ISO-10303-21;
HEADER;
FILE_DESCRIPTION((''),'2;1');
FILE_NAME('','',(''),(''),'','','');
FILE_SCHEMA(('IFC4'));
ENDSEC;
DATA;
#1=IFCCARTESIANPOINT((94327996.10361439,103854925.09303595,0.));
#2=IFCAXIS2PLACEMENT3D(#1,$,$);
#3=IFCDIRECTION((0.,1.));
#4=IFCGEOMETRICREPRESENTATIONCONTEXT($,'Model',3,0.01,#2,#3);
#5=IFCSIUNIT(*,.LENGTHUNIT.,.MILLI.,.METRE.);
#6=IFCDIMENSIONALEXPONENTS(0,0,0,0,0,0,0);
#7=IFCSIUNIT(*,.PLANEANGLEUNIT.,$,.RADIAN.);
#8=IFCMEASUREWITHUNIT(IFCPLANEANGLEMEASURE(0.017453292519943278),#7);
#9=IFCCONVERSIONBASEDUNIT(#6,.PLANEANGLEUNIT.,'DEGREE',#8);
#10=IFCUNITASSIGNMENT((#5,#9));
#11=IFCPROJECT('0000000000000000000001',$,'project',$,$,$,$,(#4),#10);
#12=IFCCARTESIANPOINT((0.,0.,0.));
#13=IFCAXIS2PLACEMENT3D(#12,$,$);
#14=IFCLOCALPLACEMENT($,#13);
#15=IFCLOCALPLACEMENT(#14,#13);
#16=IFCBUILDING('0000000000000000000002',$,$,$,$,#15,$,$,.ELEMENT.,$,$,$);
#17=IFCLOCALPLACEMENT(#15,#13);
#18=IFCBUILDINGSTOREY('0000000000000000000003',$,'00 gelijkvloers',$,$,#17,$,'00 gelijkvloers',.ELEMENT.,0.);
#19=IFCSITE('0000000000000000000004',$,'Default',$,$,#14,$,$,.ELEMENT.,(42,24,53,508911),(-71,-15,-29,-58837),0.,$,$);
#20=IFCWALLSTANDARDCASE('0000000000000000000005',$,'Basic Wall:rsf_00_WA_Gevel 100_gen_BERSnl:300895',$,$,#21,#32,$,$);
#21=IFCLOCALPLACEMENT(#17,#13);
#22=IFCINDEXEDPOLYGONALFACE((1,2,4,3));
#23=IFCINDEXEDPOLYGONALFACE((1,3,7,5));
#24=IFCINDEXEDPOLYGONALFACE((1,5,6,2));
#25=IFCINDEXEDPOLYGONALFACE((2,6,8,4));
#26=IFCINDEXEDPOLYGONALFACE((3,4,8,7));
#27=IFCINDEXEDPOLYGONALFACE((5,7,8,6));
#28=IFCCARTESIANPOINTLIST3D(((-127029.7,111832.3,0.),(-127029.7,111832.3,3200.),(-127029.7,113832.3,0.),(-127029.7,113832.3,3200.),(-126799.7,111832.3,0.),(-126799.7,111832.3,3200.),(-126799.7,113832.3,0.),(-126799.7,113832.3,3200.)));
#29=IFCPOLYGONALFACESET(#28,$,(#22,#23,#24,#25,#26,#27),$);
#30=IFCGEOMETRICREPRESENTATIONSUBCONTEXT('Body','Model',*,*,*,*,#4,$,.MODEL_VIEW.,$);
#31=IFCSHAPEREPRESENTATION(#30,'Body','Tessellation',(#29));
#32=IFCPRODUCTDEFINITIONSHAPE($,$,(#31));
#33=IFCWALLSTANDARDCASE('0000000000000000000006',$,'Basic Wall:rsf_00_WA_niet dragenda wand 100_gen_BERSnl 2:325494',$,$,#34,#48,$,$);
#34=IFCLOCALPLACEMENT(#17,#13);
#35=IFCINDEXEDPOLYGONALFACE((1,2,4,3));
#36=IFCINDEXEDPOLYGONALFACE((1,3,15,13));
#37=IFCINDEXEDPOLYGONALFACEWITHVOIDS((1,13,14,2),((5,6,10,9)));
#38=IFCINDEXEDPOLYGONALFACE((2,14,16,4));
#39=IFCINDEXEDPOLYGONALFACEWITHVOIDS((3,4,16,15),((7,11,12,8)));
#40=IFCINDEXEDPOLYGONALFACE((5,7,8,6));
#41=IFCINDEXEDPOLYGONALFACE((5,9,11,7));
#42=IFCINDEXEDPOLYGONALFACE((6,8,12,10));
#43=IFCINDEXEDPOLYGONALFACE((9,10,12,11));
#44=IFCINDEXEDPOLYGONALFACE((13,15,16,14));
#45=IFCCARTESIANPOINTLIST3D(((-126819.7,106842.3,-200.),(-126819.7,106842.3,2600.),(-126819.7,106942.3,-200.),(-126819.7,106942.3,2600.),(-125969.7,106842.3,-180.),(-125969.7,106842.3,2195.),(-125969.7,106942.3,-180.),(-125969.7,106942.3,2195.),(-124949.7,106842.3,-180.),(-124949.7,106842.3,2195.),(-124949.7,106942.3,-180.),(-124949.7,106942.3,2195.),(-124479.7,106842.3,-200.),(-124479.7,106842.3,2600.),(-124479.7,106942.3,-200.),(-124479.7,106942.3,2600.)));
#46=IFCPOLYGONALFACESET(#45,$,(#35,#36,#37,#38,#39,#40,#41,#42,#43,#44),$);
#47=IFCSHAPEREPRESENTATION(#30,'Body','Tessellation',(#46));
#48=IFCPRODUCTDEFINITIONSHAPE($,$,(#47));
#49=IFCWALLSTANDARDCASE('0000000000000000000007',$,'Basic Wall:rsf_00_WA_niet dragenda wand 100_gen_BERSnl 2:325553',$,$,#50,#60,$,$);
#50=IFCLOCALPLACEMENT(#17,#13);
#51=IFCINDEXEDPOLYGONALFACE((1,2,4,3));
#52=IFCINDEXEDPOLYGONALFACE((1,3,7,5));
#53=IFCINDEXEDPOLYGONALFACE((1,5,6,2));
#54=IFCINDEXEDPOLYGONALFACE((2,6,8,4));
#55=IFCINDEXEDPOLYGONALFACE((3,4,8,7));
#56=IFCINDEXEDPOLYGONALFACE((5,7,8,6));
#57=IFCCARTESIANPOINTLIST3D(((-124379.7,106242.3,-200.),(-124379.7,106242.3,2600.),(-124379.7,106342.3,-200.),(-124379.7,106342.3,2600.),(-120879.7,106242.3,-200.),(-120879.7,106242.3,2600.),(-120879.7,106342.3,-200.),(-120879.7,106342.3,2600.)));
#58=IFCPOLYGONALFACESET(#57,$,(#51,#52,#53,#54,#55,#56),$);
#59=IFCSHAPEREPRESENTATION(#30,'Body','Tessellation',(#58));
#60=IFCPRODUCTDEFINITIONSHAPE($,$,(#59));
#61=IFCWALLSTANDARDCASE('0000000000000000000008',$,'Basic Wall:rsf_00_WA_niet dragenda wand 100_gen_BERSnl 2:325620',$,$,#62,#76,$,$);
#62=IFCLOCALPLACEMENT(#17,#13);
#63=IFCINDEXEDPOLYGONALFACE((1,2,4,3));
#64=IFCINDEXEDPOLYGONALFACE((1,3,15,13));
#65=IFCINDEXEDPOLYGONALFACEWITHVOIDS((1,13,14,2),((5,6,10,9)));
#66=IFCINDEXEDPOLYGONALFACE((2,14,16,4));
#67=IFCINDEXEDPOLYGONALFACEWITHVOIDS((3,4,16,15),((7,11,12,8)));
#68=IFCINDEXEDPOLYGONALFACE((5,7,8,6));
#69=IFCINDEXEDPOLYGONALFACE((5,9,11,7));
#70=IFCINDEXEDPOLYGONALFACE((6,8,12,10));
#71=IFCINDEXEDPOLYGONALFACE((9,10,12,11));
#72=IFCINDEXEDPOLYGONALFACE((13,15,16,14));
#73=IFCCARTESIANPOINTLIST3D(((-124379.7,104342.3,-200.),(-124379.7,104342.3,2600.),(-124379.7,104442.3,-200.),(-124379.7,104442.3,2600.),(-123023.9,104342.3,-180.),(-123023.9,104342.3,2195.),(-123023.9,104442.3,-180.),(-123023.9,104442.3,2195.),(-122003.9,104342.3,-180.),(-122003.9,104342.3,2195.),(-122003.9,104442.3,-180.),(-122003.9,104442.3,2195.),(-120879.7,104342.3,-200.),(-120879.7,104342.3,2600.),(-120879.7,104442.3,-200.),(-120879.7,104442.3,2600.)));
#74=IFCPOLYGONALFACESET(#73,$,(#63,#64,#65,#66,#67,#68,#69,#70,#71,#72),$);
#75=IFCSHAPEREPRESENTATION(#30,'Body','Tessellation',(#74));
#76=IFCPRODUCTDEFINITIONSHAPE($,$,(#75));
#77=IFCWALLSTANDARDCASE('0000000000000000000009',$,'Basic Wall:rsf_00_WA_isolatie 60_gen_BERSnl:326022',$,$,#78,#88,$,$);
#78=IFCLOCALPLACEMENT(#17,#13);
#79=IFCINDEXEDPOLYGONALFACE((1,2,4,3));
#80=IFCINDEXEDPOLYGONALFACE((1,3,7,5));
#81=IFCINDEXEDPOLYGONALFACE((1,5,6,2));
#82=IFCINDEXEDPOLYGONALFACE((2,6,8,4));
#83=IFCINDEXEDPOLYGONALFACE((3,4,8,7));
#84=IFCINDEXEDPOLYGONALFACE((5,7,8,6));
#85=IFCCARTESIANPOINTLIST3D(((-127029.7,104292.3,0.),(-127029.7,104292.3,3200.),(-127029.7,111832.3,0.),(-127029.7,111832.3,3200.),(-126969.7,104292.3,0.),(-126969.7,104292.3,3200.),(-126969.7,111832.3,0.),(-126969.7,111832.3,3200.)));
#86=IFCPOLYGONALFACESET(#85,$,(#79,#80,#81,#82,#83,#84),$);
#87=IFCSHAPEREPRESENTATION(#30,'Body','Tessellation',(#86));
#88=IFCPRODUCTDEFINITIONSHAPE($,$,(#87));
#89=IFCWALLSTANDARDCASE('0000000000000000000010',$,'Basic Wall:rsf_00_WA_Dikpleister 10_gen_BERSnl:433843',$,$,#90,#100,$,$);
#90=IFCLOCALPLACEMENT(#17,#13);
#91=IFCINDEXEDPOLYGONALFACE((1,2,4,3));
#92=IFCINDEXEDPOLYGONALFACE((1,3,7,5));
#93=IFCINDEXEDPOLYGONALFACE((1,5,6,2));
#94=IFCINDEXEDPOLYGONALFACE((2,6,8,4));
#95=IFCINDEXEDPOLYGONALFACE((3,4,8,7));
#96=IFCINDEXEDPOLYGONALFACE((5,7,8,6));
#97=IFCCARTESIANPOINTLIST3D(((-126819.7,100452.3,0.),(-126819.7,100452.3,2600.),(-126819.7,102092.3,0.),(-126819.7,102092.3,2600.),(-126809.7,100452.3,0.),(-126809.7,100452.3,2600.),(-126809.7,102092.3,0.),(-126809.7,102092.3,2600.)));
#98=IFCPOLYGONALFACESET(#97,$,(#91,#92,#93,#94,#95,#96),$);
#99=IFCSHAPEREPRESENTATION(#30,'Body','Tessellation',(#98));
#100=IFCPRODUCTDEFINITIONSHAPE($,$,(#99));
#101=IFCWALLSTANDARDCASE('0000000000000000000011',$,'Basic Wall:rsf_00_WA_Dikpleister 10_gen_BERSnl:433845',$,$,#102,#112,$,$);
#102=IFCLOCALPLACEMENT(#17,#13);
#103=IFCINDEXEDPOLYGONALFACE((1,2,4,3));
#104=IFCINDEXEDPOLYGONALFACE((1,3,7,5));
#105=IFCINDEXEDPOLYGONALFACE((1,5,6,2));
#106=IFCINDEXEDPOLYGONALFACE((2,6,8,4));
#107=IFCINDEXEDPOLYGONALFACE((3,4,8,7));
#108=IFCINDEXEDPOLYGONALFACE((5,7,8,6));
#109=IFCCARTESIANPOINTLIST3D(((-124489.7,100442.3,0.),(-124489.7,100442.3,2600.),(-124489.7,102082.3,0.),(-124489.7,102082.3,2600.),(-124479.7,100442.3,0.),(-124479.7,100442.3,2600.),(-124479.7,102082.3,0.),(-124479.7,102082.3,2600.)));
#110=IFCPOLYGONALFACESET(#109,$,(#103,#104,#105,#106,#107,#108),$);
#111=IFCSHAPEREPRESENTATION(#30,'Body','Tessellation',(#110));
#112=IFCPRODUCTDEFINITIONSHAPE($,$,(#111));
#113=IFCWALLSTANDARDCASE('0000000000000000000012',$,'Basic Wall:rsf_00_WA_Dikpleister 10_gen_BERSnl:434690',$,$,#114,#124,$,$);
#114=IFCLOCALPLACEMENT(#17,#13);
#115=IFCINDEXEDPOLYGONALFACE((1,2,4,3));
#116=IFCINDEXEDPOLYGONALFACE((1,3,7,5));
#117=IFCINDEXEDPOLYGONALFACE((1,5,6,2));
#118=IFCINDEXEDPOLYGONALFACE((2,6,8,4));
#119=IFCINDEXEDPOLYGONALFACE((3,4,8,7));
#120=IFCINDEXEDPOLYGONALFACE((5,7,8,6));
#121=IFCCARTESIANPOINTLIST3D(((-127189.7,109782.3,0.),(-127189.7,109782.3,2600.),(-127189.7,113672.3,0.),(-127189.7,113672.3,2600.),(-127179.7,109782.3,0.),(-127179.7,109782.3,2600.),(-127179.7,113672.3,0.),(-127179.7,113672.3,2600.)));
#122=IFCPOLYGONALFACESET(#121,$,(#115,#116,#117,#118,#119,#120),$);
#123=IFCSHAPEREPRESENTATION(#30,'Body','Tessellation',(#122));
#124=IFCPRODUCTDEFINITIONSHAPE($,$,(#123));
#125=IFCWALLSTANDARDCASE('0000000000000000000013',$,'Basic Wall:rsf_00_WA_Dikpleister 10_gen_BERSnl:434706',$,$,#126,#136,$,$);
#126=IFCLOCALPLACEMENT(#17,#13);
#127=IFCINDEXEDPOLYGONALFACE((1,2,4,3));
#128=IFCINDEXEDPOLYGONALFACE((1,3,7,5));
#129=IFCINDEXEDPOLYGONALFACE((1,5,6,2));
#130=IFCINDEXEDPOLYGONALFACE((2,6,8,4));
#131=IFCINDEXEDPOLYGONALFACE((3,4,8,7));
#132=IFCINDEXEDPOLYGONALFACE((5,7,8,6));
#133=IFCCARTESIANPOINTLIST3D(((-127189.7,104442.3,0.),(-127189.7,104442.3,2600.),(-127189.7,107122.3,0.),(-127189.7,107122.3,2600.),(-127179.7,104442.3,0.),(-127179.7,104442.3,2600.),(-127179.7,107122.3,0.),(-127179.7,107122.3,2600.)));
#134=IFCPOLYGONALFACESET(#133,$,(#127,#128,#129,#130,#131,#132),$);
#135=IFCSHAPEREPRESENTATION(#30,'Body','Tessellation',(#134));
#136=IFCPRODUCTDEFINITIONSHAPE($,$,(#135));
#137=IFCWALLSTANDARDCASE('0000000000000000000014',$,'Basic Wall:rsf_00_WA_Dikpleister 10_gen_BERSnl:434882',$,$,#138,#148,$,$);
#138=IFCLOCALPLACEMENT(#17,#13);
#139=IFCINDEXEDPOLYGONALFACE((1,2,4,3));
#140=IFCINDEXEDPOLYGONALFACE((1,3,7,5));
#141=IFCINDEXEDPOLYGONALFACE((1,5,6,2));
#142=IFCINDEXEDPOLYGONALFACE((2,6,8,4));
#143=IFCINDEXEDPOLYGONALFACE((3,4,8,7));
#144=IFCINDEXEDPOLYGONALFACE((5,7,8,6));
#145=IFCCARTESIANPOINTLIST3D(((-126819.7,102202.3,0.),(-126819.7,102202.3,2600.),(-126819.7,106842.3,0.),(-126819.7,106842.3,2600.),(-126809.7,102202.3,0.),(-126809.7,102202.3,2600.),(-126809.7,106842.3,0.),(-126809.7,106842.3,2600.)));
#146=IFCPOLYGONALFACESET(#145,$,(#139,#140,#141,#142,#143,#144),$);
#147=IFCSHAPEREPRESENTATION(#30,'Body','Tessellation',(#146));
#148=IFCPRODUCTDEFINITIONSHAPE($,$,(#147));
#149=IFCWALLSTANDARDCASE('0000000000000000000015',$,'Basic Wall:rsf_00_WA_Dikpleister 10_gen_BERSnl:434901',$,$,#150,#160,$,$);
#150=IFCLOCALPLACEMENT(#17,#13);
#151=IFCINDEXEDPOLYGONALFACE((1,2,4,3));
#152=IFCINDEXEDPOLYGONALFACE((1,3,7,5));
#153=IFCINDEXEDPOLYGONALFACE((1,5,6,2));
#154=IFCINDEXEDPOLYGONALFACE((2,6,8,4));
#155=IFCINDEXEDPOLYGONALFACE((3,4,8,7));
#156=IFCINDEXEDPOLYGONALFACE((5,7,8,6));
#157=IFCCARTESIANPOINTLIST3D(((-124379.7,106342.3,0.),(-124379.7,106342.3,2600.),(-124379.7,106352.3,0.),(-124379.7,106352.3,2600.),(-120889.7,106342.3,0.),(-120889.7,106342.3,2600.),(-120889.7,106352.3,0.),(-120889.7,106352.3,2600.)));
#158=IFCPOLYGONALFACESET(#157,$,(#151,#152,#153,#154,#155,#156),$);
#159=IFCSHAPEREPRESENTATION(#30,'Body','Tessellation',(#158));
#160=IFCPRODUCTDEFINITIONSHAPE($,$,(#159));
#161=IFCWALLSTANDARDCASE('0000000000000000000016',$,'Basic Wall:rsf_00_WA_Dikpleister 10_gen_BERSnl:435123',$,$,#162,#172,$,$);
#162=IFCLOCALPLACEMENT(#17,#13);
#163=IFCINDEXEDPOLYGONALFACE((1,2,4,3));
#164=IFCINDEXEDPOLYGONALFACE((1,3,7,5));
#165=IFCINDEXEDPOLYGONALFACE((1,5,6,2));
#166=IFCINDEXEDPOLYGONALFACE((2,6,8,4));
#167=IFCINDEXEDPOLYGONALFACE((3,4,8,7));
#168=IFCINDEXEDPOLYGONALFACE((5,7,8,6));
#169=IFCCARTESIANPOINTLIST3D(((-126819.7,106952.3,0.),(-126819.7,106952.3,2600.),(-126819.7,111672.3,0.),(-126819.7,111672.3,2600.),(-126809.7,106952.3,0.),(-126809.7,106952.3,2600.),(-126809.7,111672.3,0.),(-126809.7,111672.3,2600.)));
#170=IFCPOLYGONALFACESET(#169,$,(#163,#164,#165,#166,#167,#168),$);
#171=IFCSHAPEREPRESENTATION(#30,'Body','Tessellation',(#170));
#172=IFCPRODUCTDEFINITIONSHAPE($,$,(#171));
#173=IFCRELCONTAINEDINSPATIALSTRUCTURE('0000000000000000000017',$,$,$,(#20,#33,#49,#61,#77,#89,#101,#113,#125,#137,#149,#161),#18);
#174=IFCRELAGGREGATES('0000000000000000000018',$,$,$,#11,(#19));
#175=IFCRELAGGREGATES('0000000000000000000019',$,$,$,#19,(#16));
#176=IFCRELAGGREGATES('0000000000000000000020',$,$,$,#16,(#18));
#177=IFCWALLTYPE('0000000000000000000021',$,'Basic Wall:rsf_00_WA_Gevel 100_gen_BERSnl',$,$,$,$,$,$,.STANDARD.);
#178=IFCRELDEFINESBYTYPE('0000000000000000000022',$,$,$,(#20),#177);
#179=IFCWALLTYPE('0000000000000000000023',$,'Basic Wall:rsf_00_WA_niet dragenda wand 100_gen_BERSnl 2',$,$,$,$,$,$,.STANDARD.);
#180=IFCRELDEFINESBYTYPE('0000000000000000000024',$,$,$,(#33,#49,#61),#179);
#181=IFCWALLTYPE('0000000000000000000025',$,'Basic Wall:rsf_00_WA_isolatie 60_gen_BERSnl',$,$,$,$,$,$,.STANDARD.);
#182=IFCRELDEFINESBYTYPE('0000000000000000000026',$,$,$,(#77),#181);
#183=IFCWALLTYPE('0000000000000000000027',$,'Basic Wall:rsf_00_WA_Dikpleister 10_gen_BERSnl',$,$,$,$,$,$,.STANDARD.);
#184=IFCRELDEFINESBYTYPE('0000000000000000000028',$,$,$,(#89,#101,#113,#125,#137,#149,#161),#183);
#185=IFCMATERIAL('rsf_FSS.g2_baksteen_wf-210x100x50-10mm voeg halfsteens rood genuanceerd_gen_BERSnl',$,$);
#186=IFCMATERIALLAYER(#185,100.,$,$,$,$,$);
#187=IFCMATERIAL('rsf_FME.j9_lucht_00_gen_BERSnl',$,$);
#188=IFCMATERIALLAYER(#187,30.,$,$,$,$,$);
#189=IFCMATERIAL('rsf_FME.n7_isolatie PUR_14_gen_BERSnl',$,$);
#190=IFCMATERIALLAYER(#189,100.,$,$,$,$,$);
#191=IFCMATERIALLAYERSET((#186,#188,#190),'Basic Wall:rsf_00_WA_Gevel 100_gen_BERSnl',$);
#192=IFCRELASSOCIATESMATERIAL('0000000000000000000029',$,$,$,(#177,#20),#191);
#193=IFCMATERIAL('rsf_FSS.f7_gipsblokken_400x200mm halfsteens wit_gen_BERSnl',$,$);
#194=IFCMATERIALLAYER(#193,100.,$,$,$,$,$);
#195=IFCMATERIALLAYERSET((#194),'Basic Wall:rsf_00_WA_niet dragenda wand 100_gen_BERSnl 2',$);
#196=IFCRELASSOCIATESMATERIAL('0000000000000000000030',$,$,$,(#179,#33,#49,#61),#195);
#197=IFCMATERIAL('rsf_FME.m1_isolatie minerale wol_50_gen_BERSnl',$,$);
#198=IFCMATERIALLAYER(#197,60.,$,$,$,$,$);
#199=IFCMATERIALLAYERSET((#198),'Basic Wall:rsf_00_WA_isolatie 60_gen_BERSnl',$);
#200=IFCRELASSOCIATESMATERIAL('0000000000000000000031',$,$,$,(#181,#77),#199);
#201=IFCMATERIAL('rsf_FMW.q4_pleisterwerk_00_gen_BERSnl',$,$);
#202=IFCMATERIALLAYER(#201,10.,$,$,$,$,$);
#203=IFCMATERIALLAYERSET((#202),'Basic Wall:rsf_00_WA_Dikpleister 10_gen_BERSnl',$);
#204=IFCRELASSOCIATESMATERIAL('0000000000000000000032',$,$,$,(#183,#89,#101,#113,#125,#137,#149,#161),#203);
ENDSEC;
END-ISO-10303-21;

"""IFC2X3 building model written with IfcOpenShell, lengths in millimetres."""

from ifc_helpers import new_model, entity, si_unit, converted_unit, direction, frame, frame_2d, origin, place, context, subcontext, project, spatial, rectangle, extrude, material, layer, layer_set, layer_usage, type_object, element, save


model = new_model("IFC2X3")

# Units and contexts
model_context = context("Model", 3, precision=0.01, world=frame((94327996.10361439, 103854925.09303595, 0.0)), true_north=direction((0.0, 1.0)))
body_context = subcontext(model_context, "Body", "Model", "MODEL_VIEW")
ifc_project = project(units=[si_unit("LENGTHUNIT", "METRE", prefix="MILLI"), converted_unit("PLANEANGLEUNIT", "DEGREE", entity("IfcPlaneAngleMeasure", 0.017453292519943278), si_unit("PLANEANGLEUNIT", "RADIAN"), dimensions=[0, 0, 0, 0, 0, 0, 0])], contexts=[model_context])

# Site, building, storey
site_placement = place(None, origin())
site = spatial("IfcSite", under=ifc_project, at=site_placement, Name="Default", CompositionType="ELEMENT", RefLatitude=(42, 24, 53, 508911), RefLongitude=(-71, -15, -29, -58837), RefElevation=0.0)
building_placement = place(site_placement, origin())
building = spatial("IfcBuilding", under=site, at=building_placement, CompositionType="ELEMENT")
storey_placement = place(building_placement, origin())
storey = spatial("IfcBuildingStorey", under=building, at=storey_placement, Name="00 gelijkvloers", LongName="00 gelijkvloers", CompositionType="ELEMENT", Elevation=0.0)

# Wall
ifc_material_1 = material(Name="rsf_FSS.g2_baksteen_wf-210x100x50-10mm voeg halfsteens rood genuanceerd_gen_BERSnl")
ifc_layer_1 = layer(ifc_material_1, 100.0)
ifc_material_2 = material(Name="rsf_FME.j9_lucht_00_gen_BERSnl")
ifc_layer_2 = layer(ifc_material_2, 30.0)
ifc_material_3 = material(Name="rsf_FME.n7_isolatie PUR_14_gen_BERSnl")
ifc_layer_3 = layer(ifc_material_3, 100.0)
ifc_layer_set_1 = layer_set([ifc_layer_1, ifc_layer_2, ifc_layer_3], Name="Basic Wall:rsf_00_WA_Gevel 100_gen_BERSnl")
ifc_layer_usage_1 = layer_usage(ifc_layer_set_1, "AXIS2", "NEGATIVE", 115.0)
wall_type_1 = type_object("IfcWallType", Name="Basic Wall:rsf_00_WA_Gevel 100_gen_BERSnl", PredefinedType="STANDARD", material=ifc_layer_set_1)
wall_1_placement = place(storey_placement, frame((-126914.7, 113832.3, 0.0), z_axis=(0.0, 0.0, 1.0), x_axis=(0.0, -1.0, 0.0)))
element("IfcWallStandardCase", 1, at=wall_1_placement, inside=storey, type_object=wall_type_1, material=ifc_layer_usage_1, Name="Basic Wall:rsf_00_WA_Gevel 100_gen_BERSnl:300895", context=body_context, shape_type="SweptSolid", body=[
    extrude(rectangle(XDim=2000.0, YDim=230.0, at=frame_2d((1000.0, 0.0), x_axis=(-1.0, 0.0))), origin(), (0.0, 0.0, 1.0), 3200.0),
])

# Wall, opening
ifc_material_4 = material(Name="rsf_FSS.f7_gipsblokken_400x200mm halfsteens wit_gen_BERSnl")
ifc_layer_4 = layer(ifc_material_4, 100.0)
ifc_layer_set_2 = layer_set([ifc_layer_4], Name="Basic Wall:rsf_00_WA_niet dragenda wand 100_gen_BERSnl 2")
ifc_layer_usage_2 = layer_usage(ifc_layer_set_2, "AXIS2", "NEGATIVE", 50.0)
wall_type_2 = type_object("IfcWallType", Name="Basic Wall:rsf_00_WA_niet dragenda wand 100_gen_BERSnl 2", PredefinedType="STANDARD", material=ifc_layer_set_2)
wall_2_placement = place(storey_placement, frame((-124479.7, 106892.3, -200.0), z_axis=(0.0, 0.0, 1.0), x_axis=(-1.0, 0.0, 0.0)))
wall_2 = element("IfcWallStandardCase", 2, at=wall_2_placement, inside=storey, type_object=wall_type_2, material=ifc_layer_usage_2, Name="Basic Wall:rsf_00_WA_niet dragenda wand 100_gen_BERSnl 2:325494", context=body_context, shape_type="SweptSolid", body=[
    extrude(rectangle(XDim=2340.0, YDim=100.0, at=frame_2d((1170.0, 0.0), x_axis=(-1.0, 0.0))), origin(), (0.0, 0.0, 1.0), 2800.0),
])
opening_1_placement = place(wall_2_placement, frame((1490.0, 50.0, 20.0)))
element("IfcOpeningElement", 3, at=opening_1_placement, cuts=wall_2, ObjectType="Opening", context=body_context, shape_type="SweptSolid", body=[
    extrude(rectangle(XDim=2375.0, YDim=1020.0, at=frame_2d((1187.5, 510.0), x_axis=(-1.0, 0.0))), frame((0.0, 0.0, 0.0), z_axis=(0.0, -1.0, 0.0), x_axis=(0.0, 0.0, 1.0)), (0.0, 0.0, 1.0), 100.0),
])

# Wall
ifc_layer_usage_3 = layer_usage(ifc_layer_set_2, "AXIS2", "POSITIVE", -50.0)
wall_3_placement = place(storey_placement, frame((-124379.7, 106292.3, -200.0)))
element("IfcWallStandardCase", 4, at=wall_3_placement, inside=storey, type_object=wall_type_2, material=ifc_layer_usage_3, Name="Basic Wall:rsf_00_WA_niet dragenda wand 100_gen_BERSnl 2:325553", context=body_context, shape_type="SweptSolid", body=[
    extrude(rectangle(XDim=3500.0, YDim=100.0, at=frame_2d((1750.0, 0.0), x_axis=(-1.0, 0.0))), origin(), (0.0, 0.0, 1.0), 2800.0),
])

# Wall, opening
ifc_layer_usage_4 = layer_usage(ifc_layer_set_2, "AXIS2", "POSITIVE", -50.0)
wall_4_placement = place(storey_placement, frame((-124379.7, 104392.3, -200.0)))
wall_4 = element("IfcWallStandardCase", 5, at=wall_4_placement, inside=storey, type_object=wall_type_2, material=ifc_layer_usage_4, Name="Basic Wall:rsf_00_WA_niet dragenda wand 100_gen_BERSnl 2:325620", context=body_context, shape_type="SweptSolid", body=[
    extrude(rectangle(XDim=3500.0, YDim=100.0, at=frame_2d((1750.0, 0.0), x_axis=(-1.0, 0.0))), origin(), (0.0, 0.0, 1.0), 2800.0),
])
opening_2_placement = place(wall_4_placement, frame((2375.8, 50.0, 20.0)))
element("IfcOpeningElement", 6, at=opening_2_placement, cuts=wall_4, ObjectType="Opening", context=body_context, shape_type="SweptSolid", body=[
    extrude(rectangle(XDim=2375.0, YDim=1020.0, at=frame_2d((1187.5, 510.0), x_axis=(-1.0, 0.0))), frame((0.0, 0.0, 0.0), z_axis=(0.0, -1.0, 0.0), x_axis=(0.0, 0.0, 1.0)), (0.0, 0.0, 1.0), 100.0),
])

# Walls
ifc_material_5 = material(Name="rsf_FME.m1_isolatie minerale wol_50_gen_BERSnl")
ifc_layer_5 = layer(ifc_material_5, 60.0)
ifc_layer_set_3 = layer_set([ifc_layer_5], Name="Basic Wall:rsf_00_WA_isolatie 60_gen_BERSnl")
ifc_layer_usage_5 = layer_usage(ifc_layer_set_3, "AXIS2", "NEGATIVE", 30.0)
wall_type_3 = type_object("IfcWallType", Name="Basic Wall:rsf_00_WA_isolatie 60_gen_BERSnl", PredefinedType="STANDARD", material=ifc_layer_set_3)
wall_5_placement = place(storey_placement, frame((-126999.7, 111832.3, 0.0), z_axis=(0.0, 0.0, 1.0), x_axis=(0.0, -1.0, 0.0)))
element("IfcWallStandardCase", 7, at=wall_5_placement, inside=storey, type_object=wall_type_3, material=ifc_layer_usage_5, Name="Basic Wall:rsf_00_WA_isolatie 60_gen_BERSnl:326022", context=body_context, shape_type="SweptSolid", body=[
    extrude(rectangle(XDim=7540.0, YDim=60.0, at=frame_2d((3770.0, 0.0), x_axis=(-1.0, 0.0))), origin(), (0.0, 0.0, 1.0), 3200.0),
])
ifc_material_6 = material(Name="rsf_FMW.q4_pleisterwerk_00_gen_BERSnl")
ifc_layer_6 = layer(ifc_material_6, 10.0)
ifc_layer_set_4 = layer_set([ifc_layer_6], Name="Basic Wall:rsf_00_WA_Dikpleister 10_gen_BERSnl")
ifc_layer_usage_6 = layer_usage(ifc_layer_set_4, "AXIS2", "POSITIVE", -5.0)
wall_type_4 = type_object("IfcWallType", Name="Basic Wall:rsf_00_WA_Dikpleister 10_gen_BERSnl", PredefinedType="STANDARD", material=ifc_layer_set_4)
wall_6_placement = place(storey_placement, frame((-126814.7, 102092.3, 0.0), z_axis=(0.0, 0.0, 1.0), x_axis=(0.0, -1.0, 0.0)))
element("IfcWallStandardCase", 8, at=wall_6_placement, inside=storey, type_object=wall_type_4, material=ifc_layer_usage_6, Name="Basic Wall:rsf_00_WA_Dikpleister 10_gen_BERSnl:433843", context=body_context, shape_type="SweptSolid", body=[
    extrude(rectangle(XDim=1640.0, YDim=10.0, at=frame_2d((820.0, 0.0), x_axis=(-1.0, 0.0))), origin(), (0.0, 0.0, 1.0), 2600.0),
])

# Walls
ifc_layer_usage_7 = layer_usage(ifc_layer_set_4, "AXIS2", "POSITIVE", -5.0)
wall_7_placement = place(storey_placement, frame((-124484.7, 100442.3, 0.0), z_axis=(0.0, 0.0, 1.0), x_axis=(0.0, 1.0, 0.0)))
element("IfcWallStandardCase", 9, at=wall_7_placement, inside=storey, type_object=wall_type_4, material=ifc_layer_usage_7, Name="Basic Wall:rsf_00_WA_Dikpleister 10_gen_BERSnl:433845", context=body_context, shape_type="SweptSolid", body=[
    extrude(rectangle(XDim=1640.0, YDim=10.0, at=frame_2d((820.0, 0.0), x_axis=(-1.0, 0.0))), origin(), (0.0, 0.0, 1.0), 2600.0),
])
ifc_layer_usage_8 = layer_usage(ifc_layer_set_4, "AXIS2", "POSITIVE", -5.0)
wall_8_placement = place(storey_placement, frame((-127184.7, 109782.3, 0.0), z_axis=(0.0, 0.0, 1.0), x_axis=(0.0, 1.0, 0.0)))
element("IfcWallStandardCase", 10, at=wall_8_placement, inside=storey, type_object=wall_type_4, material=ifc_layer_usage_8, Name="Basic Wall:rsf_00_WA_Dikpleister 10_gen_BERSnl:434690", context=body_context, shape_type="SweptSolid", body=[
    extrude(rectangle(XDim=3890.0, YDim=10.0, at=frame_2d((1945.0, 0.0), x_axis=(-1.0, 0.0))), origin(), (0.0, 0.0, 1.0), 2600.0),
])

# Wall
ifc_layer_usage_9 = layer_usage(ifc_layer_set_4, "AXIS2", "POSITIVE", -5.0)
wall_9_placement = place(storey_placement, frame((-127184.7, 104442.3, 0.0), z_axis=(0.0, 0.0, 1.0), x_axis=(0.0, 1.0, 0.0)))
element("IfcWallStandardCase", 11, at=wall_9_placement, inside=storey, type_object=wall_type_4, material=ifc_layer_usage_9, Name="Basic Wall:rsf_00_WA_Dikpleister 10_gen_BERSnl:434706", context=body_context, shape_type="SweptSolid", body=[
    extrude(rectangle(XDim=2680.0, YDim=10.0, at=frame_2d((1340.0, 0.0), x_axis=(-1.0, 0.0))), origin(), (0.0, 0.0, 1.0), 2600.0),
])

# Wall
ifc_layer_usage_10 = layer_usage(ifc_layer_set_4, "AXIS2", "POSITIVE", -5.0)
wall_10_placement = place(storey_placement, frame((-126814.7, 106842.3, 0.0), z_axis=(0.0, 0.0, 1.0), x_axis=(0.0, -1.0, 0.0)))
element("IfcWallStandardCase", 12, at=wall_10_placement, inside=storey, type_object=wall_type_4, material=ifc_layer_usage_10, Name="Basic Wall:rsf_00_WA_Dikpleister 10_gen_BERSnl:434882", context=body_context, shape_type="SweptSolid", body=[
    extrude(rectangle(XDim=4640.0, YDim=10.0, at=frame_2d((2320.0, 0.0), x_axis=(-1.0, 0.0))), origin(), (0.0, 0.0, 1.0), 2600.0),
])

# Wall
ifc_layer_usage_11 = layer_usage(ifc_layer_set_4, "AXIS2", "POSITIVE", -5.0)
wall_11_placement = place(storey_placement, frame((-124379.7, 106347.3, 0.0)))
element("IfcWallStandardCase", 13, at=wall_11_placement, inside=storey, type_object=wall_type_4, material=ifc_layer_usage_11, Name="Basic Wall:rsf_00_WA_Dikpleister 10_gen_BERSnl:434901", context=body_context, shape_type="SweptSolid", body=[
    extrude(rectangle(XDim=3490.0, YDim=10.0, at=frame_2d((1745.0, 0.0), x_axis=(-1.0, 0.0))), origin(), (0.0, 0.0, 1.0), 2600.0),
])

# Wall
ifc_layer_usage_12 = layer_usage(ifc_layer_set_4, "AXIS2", "POSITIVE", -5.0)
wall_12_placement = place(storey_placement, frame((-126814.7, 106952.3, 0.0), z_axis=(0.0, 0.0, 1.0), x_axis=(0.0, 1.0, 0.0)))
element("IfcWallStandardCase", 14, at=wall_12_placement, inside=storey, type_object=wall_type_4, material=ifc_layer_usage_12, Name="Basic Wall:rsf_00_WA_Dikpleister 10_gen_BERSnl:435123", context=body_context, shape_type="SweptSolid", body=[
    extrude(rectangle(XDim=4720.0, YDim=10.0, at=frame_2d((2360.0, 0.0), x_axis=(-1.0, 0.0))), origin(), (0.0, 0.0, 1.0), 2600.0),
])

save(model, "model.ifc")
